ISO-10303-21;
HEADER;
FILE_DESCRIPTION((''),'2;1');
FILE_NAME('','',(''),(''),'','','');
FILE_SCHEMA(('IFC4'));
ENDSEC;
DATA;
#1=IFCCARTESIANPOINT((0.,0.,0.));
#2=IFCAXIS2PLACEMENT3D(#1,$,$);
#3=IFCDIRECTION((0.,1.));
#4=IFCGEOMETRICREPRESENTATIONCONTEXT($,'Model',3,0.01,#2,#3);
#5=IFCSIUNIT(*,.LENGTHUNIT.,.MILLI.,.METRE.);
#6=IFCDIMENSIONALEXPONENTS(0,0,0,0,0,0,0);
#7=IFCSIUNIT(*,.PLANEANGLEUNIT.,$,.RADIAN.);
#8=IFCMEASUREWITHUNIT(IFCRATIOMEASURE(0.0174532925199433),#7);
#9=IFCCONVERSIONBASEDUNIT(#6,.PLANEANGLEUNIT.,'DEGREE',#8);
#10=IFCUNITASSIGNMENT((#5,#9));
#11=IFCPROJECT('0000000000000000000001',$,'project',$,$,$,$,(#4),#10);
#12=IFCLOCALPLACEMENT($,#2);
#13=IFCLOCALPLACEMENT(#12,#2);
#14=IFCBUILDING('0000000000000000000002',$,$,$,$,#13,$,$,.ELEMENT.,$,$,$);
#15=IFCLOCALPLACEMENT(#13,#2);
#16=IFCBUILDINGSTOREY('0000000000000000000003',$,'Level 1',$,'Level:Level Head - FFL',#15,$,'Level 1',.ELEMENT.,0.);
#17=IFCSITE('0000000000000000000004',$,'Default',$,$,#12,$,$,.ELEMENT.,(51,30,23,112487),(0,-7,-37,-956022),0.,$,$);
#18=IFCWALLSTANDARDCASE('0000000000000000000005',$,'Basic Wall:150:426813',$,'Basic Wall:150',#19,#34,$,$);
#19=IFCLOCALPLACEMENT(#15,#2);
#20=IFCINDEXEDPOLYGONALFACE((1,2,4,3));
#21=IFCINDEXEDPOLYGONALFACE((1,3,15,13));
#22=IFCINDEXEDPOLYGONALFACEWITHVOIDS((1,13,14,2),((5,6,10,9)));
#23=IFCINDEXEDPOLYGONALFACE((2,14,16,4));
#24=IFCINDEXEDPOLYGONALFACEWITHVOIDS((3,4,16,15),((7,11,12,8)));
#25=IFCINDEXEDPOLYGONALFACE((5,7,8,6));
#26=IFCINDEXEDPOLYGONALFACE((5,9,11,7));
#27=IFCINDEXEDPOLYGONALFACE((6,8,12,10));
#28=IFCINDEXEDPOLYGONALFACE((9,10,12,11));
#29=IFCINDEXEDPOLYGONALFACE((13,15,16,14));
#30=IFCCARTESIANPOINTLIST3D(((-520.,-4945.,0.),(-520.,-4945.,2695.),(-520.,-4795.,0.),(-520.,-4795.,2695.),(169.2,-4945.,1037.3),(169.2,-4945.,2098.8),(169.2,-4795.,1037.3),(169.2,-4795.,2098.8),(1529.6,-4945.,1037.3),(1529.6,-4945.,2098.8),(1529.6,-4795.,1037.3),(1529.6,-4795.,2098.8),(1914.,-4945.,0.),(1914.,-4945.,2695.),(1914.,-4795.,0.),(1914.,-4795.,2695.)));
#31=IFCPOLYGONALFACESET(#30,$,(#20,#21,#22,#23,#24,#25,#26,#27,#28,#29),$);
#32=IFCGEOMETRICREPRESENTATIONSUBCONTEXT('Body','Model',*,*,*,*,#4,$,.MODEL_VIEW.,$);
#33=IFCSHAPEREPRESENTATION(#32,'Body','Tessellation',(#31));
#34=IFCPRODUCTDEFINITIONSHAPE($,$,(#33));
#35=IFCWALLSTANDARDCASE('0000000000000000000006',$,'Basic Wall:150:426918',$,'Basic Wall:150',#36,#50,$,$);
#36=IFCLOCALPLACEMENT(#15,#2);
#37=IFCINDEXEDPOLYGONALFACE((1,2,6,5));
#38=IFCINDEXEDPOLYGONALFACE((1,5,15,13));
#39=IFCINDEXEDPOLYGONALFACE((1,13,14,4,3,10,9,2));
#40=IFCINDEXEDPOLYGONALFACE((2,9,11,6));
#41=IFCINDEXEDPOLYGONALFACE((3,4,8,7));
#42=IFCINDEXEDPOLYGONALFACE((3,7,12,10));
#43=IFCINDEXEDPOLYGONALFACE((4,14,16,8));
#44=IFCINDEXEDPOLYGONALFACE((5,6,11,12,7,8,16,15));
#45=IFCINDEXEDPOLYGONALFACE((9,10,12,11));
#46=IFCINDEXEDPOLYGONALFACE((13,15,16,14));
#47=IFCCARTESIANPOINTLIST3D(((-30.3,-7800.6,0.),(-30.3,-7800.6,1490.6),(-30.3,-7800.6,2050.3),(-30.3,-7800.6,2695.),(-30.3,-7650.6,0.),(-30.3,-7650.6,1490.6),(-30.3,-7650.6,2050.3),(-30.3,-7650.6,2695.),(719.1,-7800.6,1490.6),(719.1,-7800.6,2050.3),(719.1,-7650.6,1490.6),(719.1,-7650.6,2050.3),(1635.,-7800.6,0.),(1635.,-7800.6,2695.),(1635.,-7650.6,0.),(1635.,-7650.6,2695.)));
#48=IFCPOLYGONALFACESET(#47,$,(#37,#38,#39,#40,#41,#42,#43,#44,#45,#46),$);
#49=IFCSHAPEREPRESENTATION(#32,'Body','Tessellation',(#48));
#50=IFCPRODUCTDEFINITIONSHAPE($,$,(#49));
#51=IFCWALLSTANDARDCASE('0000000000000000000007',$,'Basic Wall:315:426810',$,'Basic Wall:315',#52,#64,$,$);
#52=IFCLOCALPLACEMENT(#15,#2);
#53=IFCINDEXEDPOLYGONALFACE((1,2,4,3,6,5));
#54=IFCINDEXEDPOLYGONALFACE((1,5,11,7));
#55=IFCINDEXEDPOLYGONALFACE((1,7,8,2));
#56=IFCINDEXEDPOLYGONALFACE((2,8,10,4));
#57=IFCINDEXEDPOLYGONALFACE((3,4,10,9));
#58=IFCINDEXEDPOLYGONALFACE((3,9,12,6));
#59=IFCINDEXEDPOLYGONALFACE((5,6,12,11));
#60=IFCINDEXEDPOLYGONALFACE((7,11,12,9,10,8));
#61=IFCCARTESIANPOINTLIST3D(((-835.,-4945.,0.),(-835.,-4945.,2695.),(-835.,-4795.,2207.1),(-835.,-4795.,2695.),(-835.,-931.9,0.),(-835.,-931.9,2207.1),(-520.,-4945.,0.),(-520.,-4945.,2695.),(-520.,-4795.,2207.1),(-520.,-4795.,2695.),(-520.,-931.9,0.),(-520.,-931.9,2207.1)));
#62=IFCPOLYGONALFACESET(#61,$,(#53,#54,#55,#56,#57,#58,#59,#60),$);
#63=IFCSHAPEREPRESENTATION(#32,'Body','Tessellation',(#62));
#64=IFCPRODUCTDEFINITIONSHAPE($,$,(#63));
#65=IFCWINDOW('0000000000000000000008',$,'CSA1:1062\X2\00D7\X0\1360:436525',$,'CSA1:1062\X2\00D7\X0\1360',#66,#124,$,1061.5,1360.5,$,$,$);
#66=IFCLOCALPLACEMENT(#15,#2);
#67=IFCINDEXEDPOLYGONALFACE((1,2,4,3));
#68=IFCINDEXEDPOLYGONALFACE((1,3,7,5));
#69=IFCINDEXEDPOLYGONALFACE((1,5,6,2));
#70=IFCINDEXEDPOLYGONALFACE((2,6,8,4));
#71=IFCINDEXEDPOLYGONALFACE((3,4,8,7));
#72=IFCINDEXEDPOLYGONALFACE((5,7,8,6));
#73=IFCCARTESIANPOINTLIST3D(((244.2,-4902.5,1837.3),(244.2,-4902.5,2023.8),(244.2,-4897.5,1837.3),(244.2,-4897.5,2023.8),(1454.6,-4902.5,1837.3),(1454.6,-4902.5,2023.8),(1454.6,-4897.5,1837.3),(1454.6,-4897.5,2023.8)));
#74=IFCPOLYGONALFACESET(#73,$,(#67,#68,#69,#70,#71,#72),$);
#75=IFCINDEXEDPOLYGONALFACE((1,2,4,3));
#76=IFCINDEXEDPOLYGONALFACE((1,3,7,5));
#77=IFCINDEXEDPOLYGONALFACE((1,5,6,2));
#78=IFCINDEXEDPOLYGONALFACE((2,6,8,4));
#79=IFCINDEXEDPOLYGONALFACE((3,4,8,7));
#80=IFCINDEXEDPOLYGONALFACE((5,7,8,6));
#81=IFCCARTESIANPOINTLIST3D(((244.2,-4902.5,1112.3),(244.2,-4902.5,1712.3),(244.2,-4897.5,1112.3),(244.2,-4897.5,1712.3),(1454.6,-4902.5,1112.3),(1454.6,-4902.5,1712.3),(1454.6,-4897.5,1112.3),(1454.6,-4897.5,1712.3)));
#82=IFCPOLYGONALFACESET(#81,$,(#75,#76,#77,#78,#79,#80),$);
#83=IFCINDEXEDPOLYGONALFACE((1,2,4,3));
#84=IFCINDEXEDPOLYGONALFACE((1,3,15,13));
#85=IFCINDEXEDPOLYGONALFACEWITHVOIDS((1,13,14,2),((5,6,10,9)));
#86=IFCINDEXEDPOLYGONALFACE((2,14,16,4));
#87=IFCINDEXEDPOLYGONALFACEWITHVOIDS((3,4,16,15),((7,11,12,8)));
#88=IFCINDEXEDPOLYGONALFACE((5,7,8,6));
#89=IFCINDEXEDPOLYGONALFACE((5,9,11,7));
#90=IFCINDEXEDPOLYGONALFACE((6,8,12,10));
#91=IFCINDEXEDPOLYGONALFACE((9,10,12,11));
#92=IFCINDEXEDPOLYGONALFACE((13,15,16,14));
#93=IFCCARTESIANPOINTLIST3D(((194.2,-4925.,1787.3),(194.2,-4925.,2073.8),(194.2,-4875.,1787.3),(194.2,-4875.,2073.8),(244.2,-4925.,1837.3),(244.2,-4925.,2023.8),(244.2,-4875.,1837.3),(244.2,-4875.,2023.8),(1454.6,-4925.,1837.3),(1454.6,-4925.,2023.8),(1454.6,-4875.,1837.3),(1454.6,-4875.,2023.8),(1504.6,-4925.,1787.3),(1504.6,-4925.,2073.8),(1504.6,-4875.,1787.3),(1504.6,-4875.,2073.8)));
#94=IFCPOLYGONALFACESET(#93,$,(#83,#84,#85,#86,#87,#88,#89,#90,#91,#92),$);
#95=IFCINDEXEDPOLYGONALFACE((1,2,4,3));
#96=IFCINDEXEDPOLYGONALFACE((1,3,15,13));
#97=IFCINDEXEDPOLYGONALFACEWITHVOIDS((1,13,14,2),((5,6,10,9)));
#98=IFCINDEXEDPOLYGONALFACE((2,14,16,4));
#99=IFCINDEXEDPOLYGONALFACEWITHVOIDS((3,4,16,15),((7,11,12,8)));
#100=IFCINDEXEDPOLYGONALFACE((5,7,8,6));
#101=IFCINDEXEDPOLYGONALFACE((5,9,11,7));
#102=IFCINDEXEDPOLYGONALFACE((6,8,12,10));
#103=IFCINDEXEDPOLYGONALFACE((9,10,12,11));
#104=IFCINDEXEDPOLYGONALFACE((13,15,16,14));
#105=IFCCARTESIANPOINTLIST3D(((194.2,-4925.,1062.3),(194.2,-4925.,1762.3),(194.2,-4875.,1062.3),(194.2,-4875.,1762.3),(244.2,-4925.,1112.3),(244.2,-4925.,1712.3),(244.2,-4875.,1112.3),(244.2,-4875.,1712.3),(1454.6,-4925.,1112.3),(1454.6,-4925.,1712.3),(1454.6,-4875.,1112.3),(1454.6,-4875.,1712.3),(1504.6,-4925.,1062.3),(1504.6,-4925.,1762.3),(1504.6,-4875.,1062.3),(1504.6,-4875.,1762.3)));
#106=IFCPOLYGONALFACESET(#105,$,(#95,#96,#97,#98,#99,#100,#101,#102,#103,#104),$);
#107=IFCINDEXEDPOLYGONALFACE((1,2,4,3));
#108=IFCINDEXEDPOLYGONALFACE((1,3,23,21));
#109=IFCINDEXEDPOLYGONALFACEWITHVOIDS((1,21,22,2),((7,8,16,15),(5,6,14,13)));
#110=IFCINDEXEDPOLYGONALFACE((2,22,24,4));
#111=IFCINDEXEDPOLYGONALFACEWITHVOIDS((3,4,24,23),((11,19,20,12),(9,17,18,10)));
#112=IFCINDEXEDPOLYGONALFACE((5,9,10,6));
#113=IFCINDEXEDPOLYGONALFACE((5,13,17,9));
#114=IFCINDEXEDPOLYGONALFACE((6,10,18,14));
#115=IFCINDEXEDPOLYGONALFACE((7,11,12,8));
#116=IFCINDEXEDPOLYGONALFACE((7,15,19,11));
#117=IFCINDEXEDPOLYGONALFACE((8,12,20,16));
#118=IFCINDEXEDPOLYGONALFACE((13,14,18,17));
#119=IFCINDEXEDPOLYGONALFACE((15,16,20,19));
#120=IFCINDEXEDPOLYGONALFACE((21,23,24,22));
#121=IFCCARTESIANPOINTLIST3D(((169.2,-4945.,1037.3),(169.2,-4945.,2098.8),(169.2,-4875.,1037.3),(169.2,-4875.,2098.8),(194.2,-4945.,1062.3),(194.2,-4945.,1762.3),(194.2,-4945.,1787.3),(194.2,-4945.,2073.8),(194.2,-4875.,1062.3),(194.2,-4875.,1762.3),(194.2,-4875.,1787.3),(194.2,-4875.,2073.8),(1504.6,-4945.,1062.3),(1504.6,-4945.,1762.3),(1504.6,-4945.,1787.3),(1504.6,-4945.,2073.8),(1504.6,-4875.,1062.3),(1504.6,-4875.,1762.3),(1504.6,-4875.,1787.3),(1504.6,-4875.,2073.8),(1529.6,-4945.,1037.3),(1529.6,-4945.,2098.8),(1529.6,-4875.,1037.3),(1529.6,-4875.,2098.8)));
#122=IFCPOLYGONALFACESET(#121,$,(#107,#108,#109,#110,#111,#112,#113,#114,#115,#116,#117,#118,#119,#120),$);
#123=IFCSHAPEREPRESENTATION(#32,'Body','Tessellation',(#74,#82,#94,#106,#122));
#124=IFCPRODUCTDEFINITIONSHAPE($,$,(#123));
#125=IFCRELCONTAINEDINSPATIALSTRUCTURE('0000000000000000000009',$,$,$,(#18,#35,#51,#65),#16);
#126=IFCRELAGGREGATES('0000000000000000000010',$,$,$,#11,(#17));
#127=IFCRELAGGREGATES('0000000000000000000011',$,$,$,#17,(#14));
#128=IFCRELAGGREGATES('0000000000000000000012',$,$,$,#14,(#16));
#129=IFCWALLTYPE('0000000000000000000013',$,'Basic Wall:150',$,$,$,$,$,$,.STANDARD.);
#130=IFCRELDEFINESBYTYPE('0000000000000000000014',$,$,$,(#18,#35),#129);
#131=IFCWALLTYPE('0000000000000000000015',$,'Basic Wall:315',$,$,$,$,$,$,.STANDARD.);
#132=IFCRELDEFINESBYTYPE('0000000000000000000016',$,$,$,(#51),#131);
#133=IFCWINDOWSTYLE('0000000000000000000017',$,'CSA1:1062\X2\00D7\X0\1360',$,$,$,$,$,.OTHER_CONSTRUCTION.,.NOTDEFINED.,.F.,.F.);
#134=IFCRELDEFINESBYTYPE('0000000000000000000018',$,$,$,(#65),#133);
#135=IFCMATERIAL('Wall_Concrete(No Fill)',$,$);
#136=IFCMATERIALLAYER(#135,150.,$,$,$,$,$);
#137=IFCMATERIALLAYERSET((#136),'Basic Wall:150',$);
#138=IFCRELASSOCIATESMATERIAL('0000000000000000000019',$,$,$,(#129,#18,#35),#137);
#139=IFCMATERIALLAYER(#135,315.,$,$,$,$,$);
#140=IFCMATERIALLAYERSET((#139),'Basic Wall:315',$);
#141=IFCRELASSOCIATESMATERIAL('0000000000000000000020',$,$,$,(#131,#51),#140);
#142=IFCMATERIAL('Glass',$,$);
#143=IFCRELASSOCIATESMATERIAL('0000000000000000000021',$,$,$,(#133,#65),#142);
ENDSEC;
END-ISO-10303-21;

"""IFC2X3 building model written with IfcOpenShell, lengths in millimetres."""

from ifc_helpers import new_model, entity, si_unit, converted_unit, direction, frame, frame_2d, origin, origin_2d_with_axis, place, context, subcontext, project, spatial, polyline, rectangle, outline, extrude, source, transform, mapped, material, layer, layer_set, layer_usage, type_object, type_shapes, element, save


model = new_model("IFC2X3")

# Units and contexts
model_context = context("Model", 3, precision=0.01, world=origin(), true_north=direction((0.0, 1.0)))
body_context = subcontext(model_context, "Body", "Model", "MODEL_VIEW")
ifc_project = project(units=[si_unit("LENGTHUNIT", "METRE", prefix="MILLI"), converted_unit("PLANEANGLEUNIT", "DEGREE", entity("IfcRatioMeasure", 0.0174532925199433), si_unit("PLANEANGLEUNIT", "RADIAN"), dimensions=[0, 0, 0, 0, 0, 0, 0])], contexts=[model_context])

# Site, building, storey
site_placement = place(None, origin())
site = spatial("IfcSite", under=ifc_project, at=site_placement, Name="Default", CompositionType="ELEMENT", RefLatitude=(51, 30, 23, 112487), RefLongitude=(0, -7, -37, -956022), RefElevation=0.0)
building_placement = place(site_placement, origin())
building = spatial("IfcBuilding", under=site, at=building_placement, CompositionType="ELEMENT")
storey_placement = place(building_placement, origin())
storey = spatial("IfcBuildingStorey", under=building, at=storey_placement, Name="Level 1", ObjectType="Level:Level Head - FFL", LongName="Level 1", CompositionType="ELEMENT", Elevation=0.0)

# Shared definitions
ifc_material_1 = material(Name="Wall_Concrete(No Fill)")

# Walls, openings
ifc_layer_1 = layer(ifc_material_1, 150.0)
ifc_layer_set_1 = layer_set([ifc_layer_1], Name="Basic Wall:150")
ifc_layer_usage_1 = layer_usage(ifc_layer_set_1, "AXIS2", "NEGATIVE", 75.0)
wall_type_1 = type_object("IfcWallType", Name="Basic Wall:150", PredefinedType="STANDARD", material=ifc_layer_set_1)
wall_1_placement = place(storey_placement, frame((-520.0, -4870.0, 0.0)))
wall_1 = element("IfcWallStandardCase", 1, at=wall_1_placement, inside=storey, type_object=wall_type_1, material=ifc_layer_usage_1, Name="Basic Wall:150:426813", ObjectType="Basic Wall:150", context=body_context, shape_type="SweptSolid", body=[
    extrude(rectangle(XDim=2434.0, YDim=150.0, at=frame_2d((1217.0, 0.0), x_axis=(-1.0, 0.0))), origin(), (0.0, 0.0, 1.0), 2695.0),
])
opening_1_placement = place(wall_1_placement, origin())
element("IfcOpeningElement", 2, at=opening_1_placement, cuts=wall_1, ObjectType="Opening", context=body_context, shape_type="SweptSolid", body=[
    extrude(rectangle(XDim=1061.5, YDim=1360.5, at=frame_2d((0.0, 0.0), x_axis=(1.0, 0.0))), frame((1369.4, -75.0, 1568.0), z_axis=(0.0, 1.0, 0.0), x_axis=(0.0, 0.0, -1.0)), (0.0, 0.0, 1.0), 150.0),
])
ifc_layer_usage_2 = layer_usage(ifc_layer_set_1, "AXIS2", "NEGATIVE", 75.0)
wall_2_placement = place(storey_placement, frame((-30.3, -7725.6, 0.0)))
wall_2 = element("IfcWallStandardCase", 3, at=wall_2_placement, inside=storey, type_object=wall_type_1, material=ifc_layer_usage_2, Name="Basic Wall:150:426918", ObjectType="Basic Wall:150", context=body_context, shape_type="SweptSolid", body=[
    extrude(rectangle(XDim=1665.4, YDim=150.0, at=frame_2d((832.7, 0.0), x_axis=(-1.0, 0.0))), origin(), (0.0, 0.0, 1.0), 2695.0),
])
opening_2_placement = place(wall_2_placement, origin())
element("IfcOpeningElement", 4, at=opening_2_placement, cuts=wall_2, ObjectType="Opening", context=body_context, shape_type="SweptSolid", body=[
    extrude(rectangle(XDim=559.7, YDim=770.5, at=frame_2d((0.0, 0.0), x_axis=(1.0, 0.0))), frame((364.2, -75.0, 1770.4), z_axis=(0.0, 1.0, 0.0), x_axis=(0.0, 0.0, -1.0)), (0.0, 0.0, 1.0), 150.0),
])
ifc_layer_2 = layer(ifc_material_1, 315.0)
ifc_layer_set_2 = layer_set([ifc_layer_2], Name="Basic Wall:315")
ifc_layer_usage_3 = layer_usage(ifc_layer_set_2, "AXIS2", "NEGATIVE", 157.5)
wall_type_2 = type_object("IfcWallType", Name="Basic Wall:315", PredefinedType="STANDARD", material=ifc_layer_set_2)
wall_3_placement = place(storey_placement, frame((-677.5, -4945.0, 0.0), z_axis=(0.0, 0.0, 1.0), x_axis=(0.0, 1.0, 0.0)))
wall_3 = element("IfcWallStandardCase", 5, at=wall_3_placement, inside=storey, type_object=wall_type_2, material=ifc_layer_usage_3, Name="Basic Wall:315:426810", ObjectType="Basic Wall:315", context=body_context, shape_type="SweptSolid", body=[
    extrude(rectangle(XDim=4013.1, YDim=315.0, at=frame_2d((2006.5, 0.0), x_axis=(-1.0, 0.0))), origin(), (0.0, 0.0, 1.0), 2695.0),
])
opening_3_placement = place(wall_3_placement, origin())
element("IfcOpeningElement", 6, at=opening_3_placement, cuts=wall_3, ObjectType="Opening", context=body_context, shape_type="SweptSolid", body=[
    extrude(rectangle(XDim=688.0, YDim=3863.1, at=frame_2d((0.0, 0.0), x_axis=(1.0, 0.0))), frame((2081.5, -157.5, 2551.0), z_axis=(0.0, 1.0, 0.0), x_axis=(0.0, 0.0, -1.0)), (0.0, 0.0, 1.0), 315.0),
])

# Window
ifc_material_2 = material(Name="Glass")
window_style = type_object("IfcWindowStyle", Name="CSA1:1062×1360", ConstructionType="OTHER_CONSTRUCTION", OperationType="NOTDEFINED", ParameterTakesPrecedence=False, Sizeable=False, material=ifc_material_2)
shared_shape = source(origin(), body_context, "Body", "SweptSolid", [
    extrude(rectangle(XDim=5.0, YDim=1210.5, at=origin_2d_with_axis()), frame((680.2, 45.0, 800.0), z_axis=(0.0, 0.0, 1.0), x_axis=(0.0, 1.0, 0.0)), (0.0, 0.0, 1.0), 186.5),
    extrude(rectangle(XDim=5.0, YDim=1210.5, at=origin_2d_with_axis()), frame((680.2, 45.0, 75.0), z_axis=(0.0, 0.0, 1.0), x_axis=(0.0, 1.0, 0.0)), (0.0, 0.0, 1.0), 600.0),
    extrude(outline(polyline([(-655.2, -143.3), (655.2, -143.3), (655.2, 143.3), (-655.2, 143.3), (-655.2, -143.3)]), holes=[polyline([(-605.2, -93.3), (-605.2, 93.3), (605.2, 93.3), (605.2, -93.3), (-605.2, -93.3)])]), frame((680.2, 20.0, 893.3), z_axis=(0.0, 1.0, 0.0), x_axis=(1.0, 0.0, 0.0)), (0.0, 0.0, 1.0), 50.0),
    extrude(outline(polyline([(-655.2, -350.0), (655.2, -350.0), (655.2, 350.0), (-655.2, 350.0), (-655.2, -350.0)]), holes=[polyline([(-605.2, -300.0), (-605.2, 300.0), (605.2, 300.0), (605.2, -300.0), (-605.2, -300.0)])]), frame((680.2, 20.0, 375.0), z_axis=(0.0, 1.0, 0.0), x_axis=(1.0, 0.0, 0.0)), (0.0, 0.0, 1.0), 50.0),
    extrude(outline(polyline([(-680.2, -530.8), (680.2, -530.8), (680.2, 530.8), (-680.2, 530.8), (-680.2, -530.8)]), holes=[polyline([(-655.2, -505.8), (-655.2, -219.2), (655.2, -219.2), (655.2, -505.8), (-655.2, -505.8)]), polyline([(-655.2, -194.2), (-655.2, 505.8), (655.2, 505.8), (655.2, -194.2), (-655.2, -194.2)])]), frame((680.2, 0.0, 530.8), z_axis=(0.0, 1.0, 0.0), x_axis=(1.0, 0.0, 0.0)), (0.0, 0.0, 1.0), 70.0),
])
type_shapes(window_style, [shared_shape])
window_placement = place(storey_placement, frame((169.2, -4945.0, 1037.3)))
element("IfcWindow", 7, at=window_placement, inside=storey, type_object=window_style, material=ifc_material_2, Name="CSA1:1062×1360:436525", ObjectType="CSA1:1062×1360", OverallHeight=1061.5, OverallWidth=1360.5, context=body_context, shape_type="MappedRepresentation", body=[
    mapped(shared_shape, transform((0.0, 0.0, 0.0), scale=1.0)),
])

save(model, "model.ifc")
